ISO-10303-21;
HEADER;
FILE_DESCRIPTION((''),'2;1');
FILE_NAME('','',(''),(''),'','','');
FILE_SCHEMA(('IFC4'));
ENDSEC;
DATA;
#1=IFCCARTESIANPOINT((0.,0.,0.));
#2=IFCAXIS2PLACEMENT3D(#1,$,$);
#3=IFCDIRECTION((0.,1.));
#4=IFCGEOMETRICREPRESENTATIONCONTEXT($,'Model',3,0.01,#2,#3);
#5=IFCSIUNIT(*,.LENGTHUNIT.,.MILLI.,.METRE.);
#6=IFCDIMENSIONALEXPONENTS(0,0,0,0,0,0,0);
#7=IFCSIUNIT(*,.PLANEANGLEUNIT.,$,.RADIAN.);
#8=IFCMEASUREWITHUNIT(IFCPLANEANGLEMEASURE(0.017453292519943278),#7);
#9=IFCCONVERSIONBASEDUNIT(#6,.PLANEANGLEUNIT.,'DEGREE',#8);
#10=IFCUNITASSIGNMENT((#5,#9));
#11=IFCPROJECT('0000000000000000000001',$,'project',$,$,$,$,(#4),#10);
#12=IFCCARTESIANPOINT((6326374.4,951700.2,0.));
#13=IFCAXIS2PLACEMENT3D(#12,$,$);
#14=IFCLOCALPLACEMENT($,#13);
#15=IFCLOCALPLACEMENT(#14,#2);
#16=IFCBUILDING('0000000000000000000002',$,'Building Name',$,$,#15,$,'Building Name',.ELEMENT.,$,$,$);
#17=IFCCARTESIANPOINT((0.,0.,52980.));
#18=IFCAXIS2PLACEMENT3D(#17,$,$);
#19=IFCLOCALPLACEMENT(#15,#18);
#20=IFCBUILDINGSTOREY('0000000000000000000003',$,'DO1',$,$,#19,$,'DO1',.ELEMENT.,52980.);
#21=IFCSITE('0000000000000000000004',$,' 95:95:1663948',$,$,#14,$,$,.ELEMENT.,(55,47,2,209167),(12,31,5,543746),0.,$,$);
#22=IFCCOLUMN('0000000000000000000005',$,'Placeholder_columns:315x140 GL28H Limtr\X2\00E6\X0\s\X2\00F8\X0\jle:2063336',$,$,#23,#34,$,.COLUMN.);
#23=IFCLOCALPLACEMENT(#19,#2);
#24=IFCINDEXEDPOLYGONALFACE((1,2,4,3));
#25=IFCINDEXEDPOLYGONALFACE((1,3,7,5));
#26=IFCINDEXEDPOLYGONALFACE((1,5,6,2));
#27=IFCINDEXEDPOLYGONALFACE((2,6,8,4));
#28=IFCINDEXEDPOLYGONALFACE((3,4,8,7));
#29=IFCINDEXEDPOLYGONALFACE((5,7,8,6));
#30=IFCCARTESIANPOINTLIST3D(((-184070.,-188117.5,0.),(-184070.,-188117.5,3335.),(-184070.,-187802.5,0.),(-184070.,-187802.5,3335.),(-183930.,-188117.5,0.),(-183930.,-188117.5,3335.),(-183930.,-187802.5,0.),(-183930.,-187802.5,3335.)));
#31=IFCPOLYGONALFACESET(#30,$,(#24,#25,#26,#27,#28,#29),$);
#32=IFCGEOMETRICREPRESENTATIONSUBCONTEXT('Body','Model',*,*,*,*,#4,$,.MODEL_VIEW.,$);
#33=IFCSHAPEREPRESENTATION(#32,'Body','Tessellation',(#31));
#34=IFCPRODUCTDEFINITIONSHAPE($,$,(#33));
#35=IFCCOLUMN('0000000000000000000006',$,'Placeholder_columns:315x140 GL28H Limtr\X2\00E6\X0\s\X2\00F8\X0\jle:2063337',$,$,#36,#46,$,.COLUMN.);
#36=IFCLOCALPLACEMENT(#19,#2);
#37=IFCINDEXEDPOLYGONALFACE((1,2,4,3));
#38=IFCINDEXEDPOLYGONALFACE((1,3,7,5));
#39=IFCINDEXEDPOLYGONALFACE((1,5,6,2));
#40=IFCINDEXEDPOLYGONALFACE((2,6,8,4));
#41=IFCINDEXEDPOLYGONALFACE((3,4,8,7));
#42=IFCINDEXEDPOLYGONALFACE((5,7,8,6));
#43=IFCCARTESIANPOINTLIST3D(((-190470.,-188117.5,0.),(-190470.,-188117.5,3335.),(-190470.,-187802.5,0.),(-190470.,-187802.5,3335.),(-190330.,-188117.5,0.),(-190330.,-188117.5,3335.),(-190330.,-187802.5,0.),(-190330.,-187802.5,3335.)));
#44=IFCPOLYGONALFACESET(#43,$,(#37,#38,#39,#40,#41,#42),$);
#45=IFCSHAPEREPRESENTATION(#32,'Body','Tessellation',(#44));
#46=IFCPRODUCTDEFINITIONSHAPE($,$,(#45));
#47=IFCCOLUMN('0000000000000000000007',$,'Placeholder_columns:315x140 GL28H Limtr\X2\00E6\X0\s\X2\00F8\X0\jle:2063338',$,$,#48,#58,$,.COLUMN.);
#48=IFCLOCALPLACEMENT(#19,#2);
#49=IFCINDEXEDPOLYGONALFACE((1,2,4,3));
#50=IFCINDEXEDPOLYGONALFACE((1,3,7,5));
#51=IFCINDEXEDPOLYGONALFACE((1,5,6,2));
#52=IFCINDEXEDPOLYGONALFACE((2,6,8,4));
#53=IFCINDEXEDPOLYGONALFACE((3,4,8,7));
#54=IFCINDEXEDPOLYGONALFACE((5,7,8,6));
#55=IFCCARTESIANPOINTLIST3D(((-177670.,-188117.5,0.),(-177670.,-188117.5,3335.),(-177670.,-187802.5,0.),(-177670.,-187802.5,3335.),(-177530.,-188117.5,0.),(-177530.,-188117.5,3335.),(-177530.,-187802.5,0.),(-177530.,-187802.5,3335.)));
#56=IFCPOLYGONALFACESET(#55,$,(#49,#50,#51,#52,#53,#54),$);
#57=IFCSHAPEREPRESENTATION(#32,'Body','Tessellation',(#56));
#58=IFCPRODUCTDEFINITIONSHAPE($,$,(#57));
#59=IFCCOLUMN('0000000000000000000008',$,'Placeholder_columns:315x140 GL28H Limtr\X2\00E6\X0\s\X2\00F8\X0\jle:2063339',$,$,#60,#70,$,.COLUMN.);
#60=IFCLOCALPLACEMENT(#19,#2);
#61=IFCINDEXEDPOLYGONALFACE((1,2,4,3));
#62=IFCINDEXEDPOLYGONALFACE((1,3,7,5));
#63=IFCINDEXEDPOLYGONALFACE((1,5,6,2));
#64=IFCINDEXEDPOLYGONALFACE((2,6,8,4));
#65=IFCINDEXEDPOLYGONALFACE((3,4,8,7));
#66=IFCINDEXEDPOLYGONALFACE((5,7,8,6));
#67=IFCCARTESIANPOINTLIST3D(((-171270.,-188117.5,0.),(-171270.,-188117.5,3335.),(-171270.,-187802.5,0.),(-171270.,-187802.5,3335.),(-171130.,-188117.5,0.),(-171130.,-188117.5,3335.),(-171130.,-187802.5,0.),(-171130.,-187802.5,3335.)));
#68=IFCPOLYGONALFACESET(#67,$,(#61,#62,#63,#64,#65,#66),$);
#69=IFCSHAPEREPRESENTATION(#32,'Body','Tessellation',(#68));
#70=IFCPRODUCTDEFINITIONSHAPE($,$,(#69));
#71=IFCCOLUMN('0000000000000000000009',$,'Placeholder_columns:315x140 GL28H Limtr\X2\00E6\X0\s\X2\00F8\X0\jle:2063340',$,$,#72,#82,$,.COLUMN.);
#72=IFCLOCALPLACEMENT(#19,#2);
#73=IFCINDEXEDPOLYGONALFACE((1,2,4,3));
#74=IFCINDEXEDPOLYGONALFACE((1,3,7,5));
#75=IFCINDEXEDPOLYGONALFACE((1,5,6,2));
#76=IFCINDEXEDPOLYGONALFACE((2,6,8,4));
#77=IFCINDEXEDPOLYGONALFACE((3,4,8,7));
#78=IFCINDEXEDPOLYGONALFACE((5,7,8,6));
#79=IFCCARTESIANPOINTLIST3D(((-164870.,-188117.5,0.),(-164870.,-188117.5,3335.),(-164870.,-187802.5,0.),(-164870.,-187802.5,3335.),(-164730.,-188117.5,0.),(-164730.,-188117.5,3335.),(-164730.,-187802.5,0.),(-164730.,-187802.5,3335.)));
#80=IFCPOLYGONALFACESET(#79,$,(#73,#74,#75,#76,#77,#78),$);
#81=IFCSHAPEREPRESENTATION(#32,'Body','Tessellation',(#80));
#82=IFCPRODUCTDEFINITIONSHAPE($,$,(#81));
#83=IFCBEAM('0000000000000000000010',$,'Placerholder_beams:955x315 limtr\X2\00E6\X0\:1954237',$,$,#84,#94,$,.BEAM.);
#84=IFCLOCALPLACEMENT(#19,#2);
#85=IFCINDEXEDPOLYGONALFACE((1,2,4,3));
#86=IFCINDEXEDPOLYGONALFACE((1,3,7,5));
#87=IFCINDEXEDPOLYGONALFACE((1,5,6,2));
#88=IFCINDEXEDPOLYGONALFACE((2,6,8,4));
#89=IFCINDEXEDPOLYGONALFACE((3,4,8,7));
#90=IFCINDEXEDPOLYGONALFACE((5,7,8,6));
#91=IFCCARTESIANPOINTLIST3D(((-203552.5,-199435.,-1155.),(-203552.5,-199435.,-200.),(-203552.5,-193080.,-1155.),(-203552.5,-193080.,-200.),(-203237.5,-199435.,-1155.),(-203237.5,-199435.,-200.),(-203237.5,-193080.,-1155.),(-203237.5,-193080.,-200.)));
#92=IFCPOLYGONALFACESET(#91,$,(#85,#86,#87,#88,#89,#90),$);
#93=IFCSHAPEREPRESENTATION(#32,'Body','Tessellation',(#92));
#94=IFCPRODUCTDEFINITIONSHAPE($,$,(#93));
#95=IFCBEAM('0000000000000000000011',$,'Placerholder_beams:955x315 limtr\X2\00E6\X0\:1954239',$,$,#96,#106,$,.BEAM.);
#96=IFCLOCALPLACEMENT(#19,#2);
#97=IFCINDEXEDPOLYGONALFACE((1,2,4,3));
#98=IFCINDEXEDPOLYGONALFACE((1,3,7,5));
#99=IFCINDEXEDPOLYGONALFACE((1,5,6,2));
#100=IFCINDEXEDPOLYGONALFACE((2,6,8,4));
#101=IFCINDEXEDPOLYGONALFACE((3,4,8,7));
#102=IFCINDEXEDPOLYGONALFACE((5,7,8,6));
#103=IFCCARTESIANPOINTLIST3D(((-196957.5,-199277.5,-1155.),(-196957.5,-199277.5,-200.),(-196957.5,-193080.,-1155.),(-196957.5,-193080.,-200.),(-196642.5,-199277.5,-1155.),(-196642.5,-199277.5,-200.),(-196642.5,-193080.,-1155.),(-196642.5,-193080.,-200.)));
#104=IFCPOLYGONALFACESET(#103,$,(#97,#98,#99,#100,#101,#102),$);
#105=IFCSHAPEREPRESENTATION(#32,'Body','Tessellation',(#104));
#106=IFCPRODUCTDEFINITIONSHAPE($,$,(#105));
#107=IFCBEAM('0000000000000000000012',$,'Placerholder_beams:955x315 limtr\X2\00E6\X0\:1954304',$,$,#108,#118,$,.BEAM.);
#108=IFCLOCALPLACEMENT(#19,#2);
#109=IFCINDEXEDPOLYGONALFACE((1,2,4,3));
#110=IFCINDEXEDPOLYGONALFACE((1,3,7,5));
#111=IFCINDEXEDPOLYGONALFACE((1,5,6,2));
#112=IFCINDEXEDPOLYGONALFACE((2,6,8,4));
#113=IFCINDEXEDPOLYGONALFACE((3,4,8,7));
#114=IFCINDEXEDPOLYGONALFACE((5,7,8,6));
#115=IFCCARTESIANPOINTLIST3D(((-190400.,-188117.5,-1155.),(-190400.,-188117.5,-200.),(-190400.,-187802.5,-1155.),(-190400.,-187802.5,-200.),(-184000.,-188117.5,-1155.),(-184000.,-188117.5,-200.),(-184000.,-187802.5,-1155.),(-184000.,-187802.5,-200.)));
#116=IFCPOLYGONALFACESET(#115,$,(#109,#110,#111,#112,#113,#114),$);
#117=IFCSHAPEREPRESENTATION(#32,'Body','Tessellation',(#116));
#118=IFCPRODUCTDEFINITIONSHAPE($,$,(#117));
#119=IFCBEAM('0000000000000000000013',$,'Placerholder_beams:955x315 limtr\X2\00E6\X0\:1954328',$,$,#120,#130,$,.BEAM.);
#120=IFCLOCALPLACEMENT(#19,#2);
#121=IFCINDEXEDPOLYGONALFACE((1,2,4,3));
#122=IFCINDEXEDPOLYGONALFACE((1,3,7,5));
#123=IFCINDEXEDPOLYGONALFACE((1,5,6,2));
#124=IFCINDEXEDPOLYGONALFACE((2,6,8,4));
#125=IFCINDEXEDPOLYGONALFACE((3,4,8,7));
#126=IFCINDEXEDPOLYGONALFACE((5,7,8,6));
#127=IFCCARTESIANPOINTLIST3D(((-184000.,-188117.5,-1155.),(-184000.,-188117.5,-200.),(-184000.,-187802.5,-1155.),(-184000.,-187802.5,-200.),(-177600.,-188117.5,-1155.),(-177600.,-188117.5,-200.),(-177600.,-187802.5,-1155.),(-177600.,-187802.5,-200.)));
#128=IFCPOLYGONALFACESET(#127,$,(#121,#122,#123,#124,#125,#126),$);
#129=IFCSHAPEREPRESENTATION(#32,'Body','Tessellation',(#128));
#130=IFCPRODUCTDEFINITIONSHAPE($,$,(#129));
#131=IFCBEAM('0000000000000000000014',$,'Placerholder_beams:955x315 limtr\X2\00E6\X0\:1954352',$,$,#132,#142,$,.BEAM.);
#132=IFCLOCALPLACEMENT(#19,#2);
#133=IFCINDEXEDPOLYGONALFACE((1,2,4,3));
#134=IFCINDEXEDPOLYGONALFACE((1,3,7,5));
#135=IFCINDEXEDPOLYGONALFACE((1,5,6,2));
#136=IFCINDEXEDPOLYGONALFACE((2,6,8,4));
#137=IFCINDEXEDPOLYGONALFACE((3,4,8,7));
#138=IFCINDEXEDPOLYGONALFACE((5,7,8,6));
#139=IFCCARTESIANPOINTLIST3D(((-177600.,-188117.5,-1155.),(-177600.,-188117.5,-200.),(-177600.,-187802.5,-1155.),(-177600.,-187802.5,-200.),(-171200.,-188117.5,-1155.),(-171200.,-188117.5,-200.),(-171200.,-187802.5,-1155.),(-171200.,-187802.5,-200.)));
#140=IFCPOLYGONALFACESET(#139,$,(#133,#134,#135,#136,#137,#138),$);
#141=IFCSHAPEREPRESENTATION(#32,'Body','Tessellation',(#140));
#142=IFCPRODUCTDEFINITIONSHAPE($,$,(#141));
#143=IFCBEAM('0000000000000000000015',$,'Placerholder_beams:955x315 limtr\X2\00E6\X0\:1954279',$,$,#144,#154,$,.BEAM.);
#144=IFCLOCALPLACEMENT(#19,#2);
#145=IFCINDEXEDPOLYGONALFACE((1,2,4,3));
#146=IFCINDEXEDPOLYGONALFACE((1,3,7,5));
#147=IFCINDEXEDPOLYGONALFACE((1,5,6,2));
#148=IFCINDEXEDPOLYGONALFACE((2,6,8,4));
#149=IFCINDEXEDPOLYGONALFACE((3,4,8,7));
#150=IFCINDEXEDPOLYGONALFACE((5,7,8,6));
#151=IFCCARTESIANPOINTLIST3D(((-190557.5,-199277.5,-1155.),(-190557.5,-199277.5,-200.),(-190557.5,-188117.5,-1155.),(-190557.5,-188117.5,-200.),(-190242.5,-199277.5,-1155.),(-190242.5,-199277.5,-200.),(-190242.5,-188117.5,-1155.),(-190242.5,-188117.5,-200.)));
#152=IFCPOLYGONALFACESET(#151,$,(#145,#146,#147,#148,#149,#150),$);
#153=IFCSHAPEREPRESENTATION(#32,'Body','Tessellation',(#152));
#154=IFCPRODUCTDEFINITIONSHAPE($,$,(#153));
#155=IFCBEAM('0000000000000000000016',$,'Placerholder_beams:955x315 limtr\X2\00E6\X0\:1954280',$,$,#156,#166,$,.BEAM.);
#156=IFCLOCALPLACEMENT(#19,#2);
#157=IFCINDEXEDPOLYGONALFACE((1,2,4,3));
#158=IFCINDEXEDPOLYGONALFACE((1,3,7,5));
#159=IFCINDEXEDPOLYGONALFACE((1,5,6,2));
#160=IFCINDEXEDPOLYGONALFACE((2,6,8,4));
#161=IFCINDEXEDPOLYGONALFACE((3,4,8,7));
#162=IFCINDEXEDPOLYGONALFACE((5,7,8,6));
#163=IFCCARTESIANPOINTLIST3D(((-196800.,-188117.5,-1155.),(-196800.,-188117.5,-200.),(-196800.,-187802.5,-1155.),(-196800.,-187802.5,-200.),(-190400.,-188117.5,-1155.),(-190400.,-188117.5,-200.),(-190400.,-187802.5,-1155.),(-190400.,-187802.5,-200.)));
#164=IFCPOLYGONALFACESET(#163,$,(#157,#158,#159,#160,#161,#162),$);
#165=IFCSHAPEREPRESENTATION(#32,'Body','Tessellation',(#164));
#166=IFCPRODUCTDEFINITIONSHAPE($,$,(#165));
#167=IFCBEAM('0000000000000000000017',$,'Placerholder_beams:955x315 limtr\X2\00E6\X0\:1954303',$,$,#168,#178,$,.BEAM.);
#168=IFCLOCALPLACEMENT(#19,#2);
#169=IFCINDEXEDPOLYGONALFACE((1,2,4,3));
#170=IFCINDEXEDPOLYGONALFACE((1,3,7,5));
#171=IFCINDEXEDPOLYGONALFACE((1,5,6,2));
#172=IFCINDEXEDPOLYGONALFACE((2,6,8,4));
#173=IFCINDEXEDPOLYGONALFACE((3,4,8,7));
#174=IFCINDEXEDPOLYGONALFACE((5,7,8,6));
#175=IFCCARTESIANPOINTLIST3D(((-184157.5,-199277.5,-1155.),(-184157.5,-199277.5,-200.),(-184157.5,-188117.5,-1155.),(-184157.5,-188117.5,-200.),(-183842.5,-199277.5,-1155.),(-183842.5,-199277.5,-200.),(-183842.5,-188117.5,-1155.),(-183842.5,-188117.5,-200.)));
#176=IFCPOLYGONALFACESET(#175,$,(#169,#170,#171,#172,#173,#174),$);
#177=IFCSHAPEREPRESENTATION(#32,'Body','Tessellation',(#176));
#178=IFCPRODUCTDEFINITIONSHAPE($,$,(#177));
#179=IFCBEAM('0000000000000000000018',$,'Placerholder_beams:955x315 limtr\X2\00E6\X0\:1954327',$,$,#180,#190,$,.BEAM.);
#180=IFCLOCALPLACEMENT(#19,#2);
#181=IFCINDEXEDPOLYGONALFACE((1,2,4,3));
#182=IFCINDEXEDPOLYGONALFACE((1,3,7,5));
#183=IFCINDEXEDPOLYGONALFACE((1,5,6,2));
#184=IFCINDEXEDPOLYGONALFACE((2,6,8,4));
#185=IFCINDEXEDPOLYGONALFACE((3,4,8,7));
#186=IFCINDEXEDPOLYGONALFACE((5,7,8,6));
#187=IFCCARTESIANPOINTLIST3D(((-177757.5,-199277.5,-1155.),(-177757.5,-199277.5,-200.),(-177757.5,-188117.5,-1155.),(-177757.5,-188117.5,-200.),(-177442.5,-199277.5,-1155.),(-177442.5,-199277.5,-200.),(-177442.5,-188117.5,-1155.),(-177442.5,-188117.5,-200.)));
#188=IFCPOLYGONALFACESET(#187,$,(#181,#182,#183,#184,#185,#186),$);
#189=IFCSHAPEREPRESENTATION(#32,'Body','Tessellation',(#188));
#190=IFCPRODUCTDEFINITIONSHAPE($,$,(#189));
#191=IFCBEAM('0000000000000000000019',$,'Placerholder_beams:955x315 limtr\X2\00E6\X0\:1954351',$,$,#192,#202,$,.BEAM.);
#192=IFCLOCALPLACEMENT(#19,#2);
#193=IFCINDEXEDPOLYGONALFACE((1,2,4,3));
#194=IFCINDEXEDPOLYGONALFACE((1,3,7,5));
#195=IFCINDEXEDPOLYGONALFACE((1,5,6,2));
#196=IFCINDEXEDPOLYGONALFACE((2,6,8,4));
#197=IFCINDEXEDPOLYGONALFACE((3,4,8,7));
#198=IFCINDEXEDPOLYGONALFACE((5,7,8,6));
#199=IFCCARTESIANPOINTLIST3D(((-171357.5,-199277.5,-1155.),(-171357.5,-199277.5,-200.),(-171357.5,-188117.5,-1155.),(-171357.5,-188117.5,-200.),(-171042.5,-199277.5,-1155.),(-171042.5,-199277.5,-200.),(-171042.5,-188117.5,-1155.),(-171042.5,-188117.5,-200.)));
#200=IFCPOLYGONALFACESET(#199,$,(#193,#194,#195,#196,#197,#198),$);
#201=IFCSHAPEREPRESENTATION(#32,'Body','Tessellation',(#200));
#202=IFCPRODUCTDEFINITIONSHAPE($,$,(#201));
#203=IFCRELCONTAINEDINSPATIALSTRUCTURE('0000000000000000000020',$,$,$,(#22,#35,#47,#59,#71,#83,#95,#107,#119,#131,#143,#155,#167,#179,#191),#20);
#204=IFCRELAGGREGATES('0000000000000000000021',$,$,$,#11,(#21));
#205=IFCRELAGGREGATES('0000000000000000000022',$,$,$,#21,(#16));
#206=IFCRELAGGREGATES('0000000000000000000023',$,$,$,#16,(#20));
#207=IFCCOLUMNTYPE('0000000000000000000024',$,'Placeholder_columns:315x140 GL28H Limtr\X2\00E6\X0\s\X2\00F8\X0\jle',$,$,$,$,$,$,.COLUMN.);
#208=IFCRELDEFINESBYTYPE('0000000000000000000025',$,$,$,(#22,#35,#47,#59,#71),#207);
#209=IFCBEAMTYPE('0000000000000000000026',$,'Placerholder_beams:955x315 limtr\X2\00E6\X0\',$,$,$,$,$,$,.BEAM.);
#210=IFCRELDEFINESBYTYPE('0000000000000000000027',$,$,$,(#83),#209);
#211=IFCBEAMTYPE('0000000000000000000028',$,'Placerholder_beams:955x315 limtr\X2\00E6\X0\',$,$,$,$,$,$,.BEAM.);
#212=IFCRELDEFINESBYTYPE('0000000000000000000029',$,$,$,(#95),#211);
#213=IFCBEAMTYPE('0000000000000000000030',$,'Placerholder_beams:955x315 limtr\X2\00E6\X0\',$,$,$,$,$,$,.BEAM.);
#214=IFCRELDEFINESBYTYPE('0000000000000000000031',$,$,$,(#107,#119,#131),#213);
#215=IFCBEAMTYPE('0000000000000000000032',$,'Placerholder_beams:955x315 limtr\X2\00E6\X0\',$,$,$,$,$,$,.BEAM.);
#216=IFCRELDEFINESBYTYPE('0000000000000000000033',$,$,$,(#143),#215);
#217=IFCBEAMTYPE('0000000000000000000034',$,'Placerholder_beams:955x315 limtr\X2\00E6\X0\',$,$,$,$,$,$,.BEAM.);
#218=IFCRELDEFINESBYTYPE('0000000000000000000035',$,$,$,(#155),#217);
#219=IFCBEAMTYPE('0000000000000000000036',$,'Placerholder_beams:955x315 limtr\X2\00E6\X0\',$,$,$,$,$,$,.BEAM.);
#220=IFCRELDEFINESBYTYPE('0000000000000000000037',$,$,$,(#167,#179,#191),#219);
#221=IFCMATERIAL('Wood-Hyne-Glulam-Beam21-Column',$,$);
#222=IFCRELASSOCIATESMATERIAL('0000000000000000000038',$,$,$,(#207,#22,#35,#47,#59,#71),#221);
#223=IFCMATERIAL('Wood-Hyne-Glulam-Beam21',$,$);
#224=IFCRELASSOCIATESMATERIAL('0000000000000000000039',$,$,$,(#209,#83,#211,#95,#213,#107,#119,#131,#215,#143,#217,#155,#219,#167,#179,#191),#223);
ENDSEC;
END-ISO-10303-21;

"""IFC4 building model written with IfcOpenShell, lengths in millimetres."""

from ifc_helpers import new_model, entity, si_unit, converted_unit, direction, frame, origin, place, context, subcontext, project, spatial, indexed_curve, outline, extrude, source, transform, mapped, material, type_object, type_shapes, element, save


model = new_model("IFC4")

# Units and contexts
model_context = context("Model", 3, precision=0.01, world=origin(), true_north=direction((0.0, 1.0)))
body_context = subcontext(model_context, "Body", "Model", "MODEL_VIEW")
ifc_project = project(units=[si_unit("LENGTHUNIT", "METRE", prefix="MILLI"), converted_unit("PLANEANGLEUNIT", "DEGREE", entity("IfcPlaneAngleMeasure", 0.017453292519943278), si_unit("PLANEANGLEUNIT", "RADIAN"), dimensions=[0, 0, 0, 0, 0, 0, 0])], contexts=[model_context])

# Site, building, storey
site_placement = place(None, frame((6326374.4, 951700.2, 0.0)))
site = spatial("IfcSite", under=ifc_project, at=site_placement, Name=" 95:95:1663948", CompositionType="ELEMENT", RefLatitude=(55, 47, 2, 209167), RefLongitude=(12, 31, 5, 543746), RefElevation=0.0)
building_placement = place(site_placement, origin())
building = spatial("IfcBuilding", under=site, at=building_placement, Name="Building Name", LongName="Building Name", CompositionType="ELEMENT")
storey_placement = place(building_placement, frame((0.0, 0.0, 52980.0)))
storey = spatial("IfcBuildingStorey", under=building, at=storey_placement, Name="DO1", LongName="DO1", CompositionType="ELEMENT", Elevation=52980.0)

# Columns
ifc_material_1 = material(Name="Wood-Hyne-Glulam-Beam21-Column")
column_type = type_object("IfcColumnType", Name="Placeholder_columns:315x140 GL28H Limtræsøjle", PredefinedType="COLUMN", material=ifc_material_1)
shared_shape_1 = source(origin(), body_context, "Body", "SweptSolid", [
    extrude(outline(indexed_curve([(-157.5, -70.0), (157.5, -70.0), (157.5, 70.0), (-157.5, 70.0), (-157.5, -70.0)], self_intersect=False)), frame((0.0, 0.0, 52980.0), z_axis=(0.0, 0.0, 1.0), x_axis=(-1.0, 0.0, 0.0)), (0.0, 0.0, 1.0), 3335.0),
])
type_shapes(column_type, [shared_shape_1])
for number, where, z_axis, x_axis, name in (
    (1, (-184000.0, -187960.0, -52980.0), (0.0, 0.0, 1.0), (0.0, -1.0, 0.0), "Placeholder_columns:315x140 GL28H Limtræsøjle:2063336"),
    (2, (-190400.0, -187960.0, -52980.0), (0.0, 0.0, 1.0), (0.0, -1.0, 0.0), "Placeholder_columns:315x140 GL28H Limtræsøjle:2063337"),
    (3, (-177600.0, -187960.0, -52980.0), (0.0, 0.0, 1.0), (0.0, -1.0, 0.0), "Placeholder_columns:315x140 GL28H Limtræsøjle:2063338"),
    (4, (-171200.0, -187960.0, -52980.0), (0.0, 0.0, 1.0), (0.0, -1.0, 0.0), "Placeholder_columns:315x140 GL28H Limtræsøjle:2063339"),
    (5, (-164800.0, -187960.0, -52980.0), (0.0, 0.0, 1.0), (0.0, -1.0, 0.0), "Placeholder_columns:315x140 GL28H Limtræsøjle:2063340"),
):
    element("IfcColumn", number, at=place(storey_placement, frame(where, z_axis=z_axis, x_axis=x_axis)), inside=storey, type_object=column_type, material=ifc_material_1, Name=name, PredefinedType="COLUMN", context=body_context, shape_type="MappedRepresentation", body=[
        mapped(shared_shape_1, transform((0.0, 0.0, 0.0), scale=1.0)),
    ])

# Beams
ifc_material_2 = material(Name="Wood-Hyne-Glulam-Beam21")
beam_type_1 = type_object("IfcBeamType", Name="Placerholder_beams:955x315 limtræ", PredefinedType="BEAM", material=ifc_material_2)
shared_shape_2 = source(origin(), body_context, "Body", "SweptSolid", [
    extrude(outline(indexed_curve([(-3177.5, -157.5), (3177.5, -157.5), (3177.5, 157.5), (-3177.5, 157.5), (-3177.5, -157.5)], self_intersect=False)), frame((-50.0, 0.0, -477.5)), (0.0, 0.0, 1.0), 955.0),
])
type_shapes(beam_type_1, [shared_shape_2])
beam_1_placement = place(storey_placement, frame((-203395.0, -196207.5, -677.5), z_axis=(0.0, 0.0, 1.0), x_axis=(0.0, 1.0, 0.0)))
element("IfcBeam", 6, at=beam_1_placement, inside=storey, type_object=beam_type_1, material=ifc_material_2, Name="Placerholder_beams:955x315 limtræ:1954237", PredefinedType="BEAM", context=body_context, shape_type="MappedRepresentation", body=[
    mapped(shared_shape_2, transform((0.0, 0.0, 0.0), scale=1.0)),
])
beam_type_2 = type_object("IfcBeamType", Name="Placerholder_beams:955x315 limtræ", PredefinedType="BEAM", material=ifc_material_2)
shared_shape_3 = source(origin(), body_context, "Body", "SweptSolid", [
    extrude(outline(indexed_curve([(-3098.7, -157.5), (3098.7, -157.5), (3098.7, 157.5), (-3098.7, 157.5), (-3098.7, -157.5)], self_intersect=False)), frame((-506.3, 0.0, -477.5)), (0.0, 0.0, 1.0), 955.0),
])
type_shapes(beam_type_2, [shared_shape_3])
beam_2_placement = place(storey_placement, frame((-196800.0, -195672.5, -677.5), z_axis=(0.0, 0.0, 1.0), x_axis=(0.0, 1.0, 0.0)))
element("IfcBeam", 7, at=beam_2_placement, inside=storey, type_object=beam_type_2, material=ifc_material_2, Name="Placerholder_beams:955x315 limtræ:1954239", PredefinedType="BEAM", context=body_context, shape_type="MappedRepresentation", body=[
    mapped(shared_shape_3, transform((0.0, 0.0, 0.0), scale=1.0)),
])
beam_type_3 = type_object("IfcBeamType", Name="Placerholder_beams:955x315 limtræ", PredefinedType="BEAM", material=ifc_material_2)
shared_shape_4 = source(origin(), body_context, "Body", "SweptSolid", [
    extrude(outline(indexed_curve([(-3200.0, -157.5), (3200.0, -157.5), (3200.0, 157.5), (-3200.0, 157.5), (-3200.0, -157.5)], self_intersect=False)), frame((0.0, 0.0, -477.5)), (0.0, 0.0, 1.0), 955.0),
])
type_shapes(beam_type_3, [shared_shape_4])
for number, where, name in (
    (8, (-187200.0, -187960.0, -677.5), "Placerholder_beams:955x315 limtræ:1954304"),
    (9, (-180800.0, -187960.0, -677.5), "Placerholder_beams:955x315 limtræ:1954328"),
    (10, (-174400.0, -187960.0, -677.5), "Placerholder_beams:955x315 limtræ:1954352"),
):
    element("IfcBeam", number, at=place(storey_placement, frame(where)), inside=storey, type_object=beam_type_3, material=ifc_material_2, Name=name, PredefinedType="BEAM", context=body_context, shape_type="MappedRepresentation", body=[
        mapped(shared_shape_4, transform((0.0, 0.0, 0.0), scale=1.0)),
    ])
beam_type_4 = type_object("IfcBeamType", Name="Placerholder_beams:955x315 limtræ", PredefinedType="BEAM", material=ifc_material_2)
shared_shape_5 = source(origin(), body_context, "Body", "SweptSolid", [
    extrude(outline(indexed_curve([(-5580.0, -157.5), (5580.0, -157.5), (5580.0, 157.5), (-5580.0, 157.5), (-5580.0, -157.5)], self_intersect=False)), frame((0.0, 0.0, -477.5)), (0.0, 0.0, 1.0), 955.0),
])
type_shapes(beam_type_4, [shared_shape_5])
beam_3_placement = place(storey_placement, frame((-190400.0, -193697.5, -677.5), z_axis=(0.0, 0.0, 1.0), x_axis=(0.0, 1.0, 0.0)))
element("IfcBeam", 11, at=beam_3_placement, inside=storey, type_object=beam_type_4, material=ifc_material_2, Name="Placerholder_beams:955x315 limtræ:1954279", PredefinedType="BEAM", context=body_context, shape_type="MappedRepresentation", body=[
    mapped(shared_shape_5, transform((0.0, 0.0, 0.0), scale=1.0)),
])
beam_type_5 = type_object("IfcBeamType", Name="Placerholder_beams:955x315 limtræ", PredefinedType="BEAM", material=ifc_material_2)
shared_shape_6 = source(origin(), body_context, "Body", "SweptSolid", [
    extrude(outline(indexed_curve([(-3200.0, -157.5), (3200.0, -157.5), (3200.0, 157.5), (-3200.0, 157.5), (-3200.0, -157.5)], self_intersect=False)), frame((50.0, 0.0, -477.5)), (0.0, 0.0, 1.0), 955.0),
])
type_shapes(beam_type_5, [shared_shape_6])
beam_4_placement = place(storey_placement, frame((-193650.0, -187960.0, -677.5)))
element("IfcBeam", 12, at=beam_4_placement, inside=storey, type_object=beam_type_5, material=ifc_material_2, Name="Placerholder_beams:955x315 limtræ:1954280", PredefinedType="BEAM", context=body_context, shape_type="MappedRepresentation", body=[
    mapped(shared_shape_6, transform((0.0, 0.0, 0.0), scale=1.0)),
])
beam_type_6 = type_object("IfcBeamType", Name="Placerholder_beams:955x315 limtræ", PredefinedType="BEAM", material=ifc_material_2)
shared_shape_7 = source(origin(), body_context, "Body", "SweptSolid", [
    extrude(outline(indexed_curve([(-5580.0, -157.5), (5580.0, -157.5), (5580.0, 157.5), (-5580.0, 157.5), (-5580.0, -157.5)], self_intersect=False)), frame((0.0, 0.0, -477.5)), (0.0, 0.0, 1.0), 955.0),
])
type_shapes(beam_type_6, [shared_shape_7])
for number, where, z_axis, x_axis, name in (
    (13, (-184000.0, -193697.5, -677.5), (0.0, 0.0, 1.0), (0.0, 1.0, 0.0), "Placerholder_beams:955x315 limtræ:1954303"),
    (14, (-177600.0, -193697.5, -677.5), (0.0, 0.0, 1.0), (0.0, 1.0, 0.0), "Placerholder_beams:955x315 limtræ:1954327"),
    (15, (-171200.0, -193697.5, -677.5), (0.0, 0.0, 1.0), (0.0, 1.0, 0.0), "Placerholder_beams:955x315 limtræ:1954351"),
):
    element("IfcBeam", number, at=place(storey_placement, frame(where, z_axis=z_axis, x_axis=x_axis)), inside=storey, type_object=beam_type_6, material=ifc_material_2, Name=name, PredefinedType="BEAM", context=body_context, shape_type="MappedRepresentation", body=[
        mapped(shared_shape_7, transform((0.0, 0.0, 0.0), scale=1.0)),
    ])

save(model, "model.ifc")
